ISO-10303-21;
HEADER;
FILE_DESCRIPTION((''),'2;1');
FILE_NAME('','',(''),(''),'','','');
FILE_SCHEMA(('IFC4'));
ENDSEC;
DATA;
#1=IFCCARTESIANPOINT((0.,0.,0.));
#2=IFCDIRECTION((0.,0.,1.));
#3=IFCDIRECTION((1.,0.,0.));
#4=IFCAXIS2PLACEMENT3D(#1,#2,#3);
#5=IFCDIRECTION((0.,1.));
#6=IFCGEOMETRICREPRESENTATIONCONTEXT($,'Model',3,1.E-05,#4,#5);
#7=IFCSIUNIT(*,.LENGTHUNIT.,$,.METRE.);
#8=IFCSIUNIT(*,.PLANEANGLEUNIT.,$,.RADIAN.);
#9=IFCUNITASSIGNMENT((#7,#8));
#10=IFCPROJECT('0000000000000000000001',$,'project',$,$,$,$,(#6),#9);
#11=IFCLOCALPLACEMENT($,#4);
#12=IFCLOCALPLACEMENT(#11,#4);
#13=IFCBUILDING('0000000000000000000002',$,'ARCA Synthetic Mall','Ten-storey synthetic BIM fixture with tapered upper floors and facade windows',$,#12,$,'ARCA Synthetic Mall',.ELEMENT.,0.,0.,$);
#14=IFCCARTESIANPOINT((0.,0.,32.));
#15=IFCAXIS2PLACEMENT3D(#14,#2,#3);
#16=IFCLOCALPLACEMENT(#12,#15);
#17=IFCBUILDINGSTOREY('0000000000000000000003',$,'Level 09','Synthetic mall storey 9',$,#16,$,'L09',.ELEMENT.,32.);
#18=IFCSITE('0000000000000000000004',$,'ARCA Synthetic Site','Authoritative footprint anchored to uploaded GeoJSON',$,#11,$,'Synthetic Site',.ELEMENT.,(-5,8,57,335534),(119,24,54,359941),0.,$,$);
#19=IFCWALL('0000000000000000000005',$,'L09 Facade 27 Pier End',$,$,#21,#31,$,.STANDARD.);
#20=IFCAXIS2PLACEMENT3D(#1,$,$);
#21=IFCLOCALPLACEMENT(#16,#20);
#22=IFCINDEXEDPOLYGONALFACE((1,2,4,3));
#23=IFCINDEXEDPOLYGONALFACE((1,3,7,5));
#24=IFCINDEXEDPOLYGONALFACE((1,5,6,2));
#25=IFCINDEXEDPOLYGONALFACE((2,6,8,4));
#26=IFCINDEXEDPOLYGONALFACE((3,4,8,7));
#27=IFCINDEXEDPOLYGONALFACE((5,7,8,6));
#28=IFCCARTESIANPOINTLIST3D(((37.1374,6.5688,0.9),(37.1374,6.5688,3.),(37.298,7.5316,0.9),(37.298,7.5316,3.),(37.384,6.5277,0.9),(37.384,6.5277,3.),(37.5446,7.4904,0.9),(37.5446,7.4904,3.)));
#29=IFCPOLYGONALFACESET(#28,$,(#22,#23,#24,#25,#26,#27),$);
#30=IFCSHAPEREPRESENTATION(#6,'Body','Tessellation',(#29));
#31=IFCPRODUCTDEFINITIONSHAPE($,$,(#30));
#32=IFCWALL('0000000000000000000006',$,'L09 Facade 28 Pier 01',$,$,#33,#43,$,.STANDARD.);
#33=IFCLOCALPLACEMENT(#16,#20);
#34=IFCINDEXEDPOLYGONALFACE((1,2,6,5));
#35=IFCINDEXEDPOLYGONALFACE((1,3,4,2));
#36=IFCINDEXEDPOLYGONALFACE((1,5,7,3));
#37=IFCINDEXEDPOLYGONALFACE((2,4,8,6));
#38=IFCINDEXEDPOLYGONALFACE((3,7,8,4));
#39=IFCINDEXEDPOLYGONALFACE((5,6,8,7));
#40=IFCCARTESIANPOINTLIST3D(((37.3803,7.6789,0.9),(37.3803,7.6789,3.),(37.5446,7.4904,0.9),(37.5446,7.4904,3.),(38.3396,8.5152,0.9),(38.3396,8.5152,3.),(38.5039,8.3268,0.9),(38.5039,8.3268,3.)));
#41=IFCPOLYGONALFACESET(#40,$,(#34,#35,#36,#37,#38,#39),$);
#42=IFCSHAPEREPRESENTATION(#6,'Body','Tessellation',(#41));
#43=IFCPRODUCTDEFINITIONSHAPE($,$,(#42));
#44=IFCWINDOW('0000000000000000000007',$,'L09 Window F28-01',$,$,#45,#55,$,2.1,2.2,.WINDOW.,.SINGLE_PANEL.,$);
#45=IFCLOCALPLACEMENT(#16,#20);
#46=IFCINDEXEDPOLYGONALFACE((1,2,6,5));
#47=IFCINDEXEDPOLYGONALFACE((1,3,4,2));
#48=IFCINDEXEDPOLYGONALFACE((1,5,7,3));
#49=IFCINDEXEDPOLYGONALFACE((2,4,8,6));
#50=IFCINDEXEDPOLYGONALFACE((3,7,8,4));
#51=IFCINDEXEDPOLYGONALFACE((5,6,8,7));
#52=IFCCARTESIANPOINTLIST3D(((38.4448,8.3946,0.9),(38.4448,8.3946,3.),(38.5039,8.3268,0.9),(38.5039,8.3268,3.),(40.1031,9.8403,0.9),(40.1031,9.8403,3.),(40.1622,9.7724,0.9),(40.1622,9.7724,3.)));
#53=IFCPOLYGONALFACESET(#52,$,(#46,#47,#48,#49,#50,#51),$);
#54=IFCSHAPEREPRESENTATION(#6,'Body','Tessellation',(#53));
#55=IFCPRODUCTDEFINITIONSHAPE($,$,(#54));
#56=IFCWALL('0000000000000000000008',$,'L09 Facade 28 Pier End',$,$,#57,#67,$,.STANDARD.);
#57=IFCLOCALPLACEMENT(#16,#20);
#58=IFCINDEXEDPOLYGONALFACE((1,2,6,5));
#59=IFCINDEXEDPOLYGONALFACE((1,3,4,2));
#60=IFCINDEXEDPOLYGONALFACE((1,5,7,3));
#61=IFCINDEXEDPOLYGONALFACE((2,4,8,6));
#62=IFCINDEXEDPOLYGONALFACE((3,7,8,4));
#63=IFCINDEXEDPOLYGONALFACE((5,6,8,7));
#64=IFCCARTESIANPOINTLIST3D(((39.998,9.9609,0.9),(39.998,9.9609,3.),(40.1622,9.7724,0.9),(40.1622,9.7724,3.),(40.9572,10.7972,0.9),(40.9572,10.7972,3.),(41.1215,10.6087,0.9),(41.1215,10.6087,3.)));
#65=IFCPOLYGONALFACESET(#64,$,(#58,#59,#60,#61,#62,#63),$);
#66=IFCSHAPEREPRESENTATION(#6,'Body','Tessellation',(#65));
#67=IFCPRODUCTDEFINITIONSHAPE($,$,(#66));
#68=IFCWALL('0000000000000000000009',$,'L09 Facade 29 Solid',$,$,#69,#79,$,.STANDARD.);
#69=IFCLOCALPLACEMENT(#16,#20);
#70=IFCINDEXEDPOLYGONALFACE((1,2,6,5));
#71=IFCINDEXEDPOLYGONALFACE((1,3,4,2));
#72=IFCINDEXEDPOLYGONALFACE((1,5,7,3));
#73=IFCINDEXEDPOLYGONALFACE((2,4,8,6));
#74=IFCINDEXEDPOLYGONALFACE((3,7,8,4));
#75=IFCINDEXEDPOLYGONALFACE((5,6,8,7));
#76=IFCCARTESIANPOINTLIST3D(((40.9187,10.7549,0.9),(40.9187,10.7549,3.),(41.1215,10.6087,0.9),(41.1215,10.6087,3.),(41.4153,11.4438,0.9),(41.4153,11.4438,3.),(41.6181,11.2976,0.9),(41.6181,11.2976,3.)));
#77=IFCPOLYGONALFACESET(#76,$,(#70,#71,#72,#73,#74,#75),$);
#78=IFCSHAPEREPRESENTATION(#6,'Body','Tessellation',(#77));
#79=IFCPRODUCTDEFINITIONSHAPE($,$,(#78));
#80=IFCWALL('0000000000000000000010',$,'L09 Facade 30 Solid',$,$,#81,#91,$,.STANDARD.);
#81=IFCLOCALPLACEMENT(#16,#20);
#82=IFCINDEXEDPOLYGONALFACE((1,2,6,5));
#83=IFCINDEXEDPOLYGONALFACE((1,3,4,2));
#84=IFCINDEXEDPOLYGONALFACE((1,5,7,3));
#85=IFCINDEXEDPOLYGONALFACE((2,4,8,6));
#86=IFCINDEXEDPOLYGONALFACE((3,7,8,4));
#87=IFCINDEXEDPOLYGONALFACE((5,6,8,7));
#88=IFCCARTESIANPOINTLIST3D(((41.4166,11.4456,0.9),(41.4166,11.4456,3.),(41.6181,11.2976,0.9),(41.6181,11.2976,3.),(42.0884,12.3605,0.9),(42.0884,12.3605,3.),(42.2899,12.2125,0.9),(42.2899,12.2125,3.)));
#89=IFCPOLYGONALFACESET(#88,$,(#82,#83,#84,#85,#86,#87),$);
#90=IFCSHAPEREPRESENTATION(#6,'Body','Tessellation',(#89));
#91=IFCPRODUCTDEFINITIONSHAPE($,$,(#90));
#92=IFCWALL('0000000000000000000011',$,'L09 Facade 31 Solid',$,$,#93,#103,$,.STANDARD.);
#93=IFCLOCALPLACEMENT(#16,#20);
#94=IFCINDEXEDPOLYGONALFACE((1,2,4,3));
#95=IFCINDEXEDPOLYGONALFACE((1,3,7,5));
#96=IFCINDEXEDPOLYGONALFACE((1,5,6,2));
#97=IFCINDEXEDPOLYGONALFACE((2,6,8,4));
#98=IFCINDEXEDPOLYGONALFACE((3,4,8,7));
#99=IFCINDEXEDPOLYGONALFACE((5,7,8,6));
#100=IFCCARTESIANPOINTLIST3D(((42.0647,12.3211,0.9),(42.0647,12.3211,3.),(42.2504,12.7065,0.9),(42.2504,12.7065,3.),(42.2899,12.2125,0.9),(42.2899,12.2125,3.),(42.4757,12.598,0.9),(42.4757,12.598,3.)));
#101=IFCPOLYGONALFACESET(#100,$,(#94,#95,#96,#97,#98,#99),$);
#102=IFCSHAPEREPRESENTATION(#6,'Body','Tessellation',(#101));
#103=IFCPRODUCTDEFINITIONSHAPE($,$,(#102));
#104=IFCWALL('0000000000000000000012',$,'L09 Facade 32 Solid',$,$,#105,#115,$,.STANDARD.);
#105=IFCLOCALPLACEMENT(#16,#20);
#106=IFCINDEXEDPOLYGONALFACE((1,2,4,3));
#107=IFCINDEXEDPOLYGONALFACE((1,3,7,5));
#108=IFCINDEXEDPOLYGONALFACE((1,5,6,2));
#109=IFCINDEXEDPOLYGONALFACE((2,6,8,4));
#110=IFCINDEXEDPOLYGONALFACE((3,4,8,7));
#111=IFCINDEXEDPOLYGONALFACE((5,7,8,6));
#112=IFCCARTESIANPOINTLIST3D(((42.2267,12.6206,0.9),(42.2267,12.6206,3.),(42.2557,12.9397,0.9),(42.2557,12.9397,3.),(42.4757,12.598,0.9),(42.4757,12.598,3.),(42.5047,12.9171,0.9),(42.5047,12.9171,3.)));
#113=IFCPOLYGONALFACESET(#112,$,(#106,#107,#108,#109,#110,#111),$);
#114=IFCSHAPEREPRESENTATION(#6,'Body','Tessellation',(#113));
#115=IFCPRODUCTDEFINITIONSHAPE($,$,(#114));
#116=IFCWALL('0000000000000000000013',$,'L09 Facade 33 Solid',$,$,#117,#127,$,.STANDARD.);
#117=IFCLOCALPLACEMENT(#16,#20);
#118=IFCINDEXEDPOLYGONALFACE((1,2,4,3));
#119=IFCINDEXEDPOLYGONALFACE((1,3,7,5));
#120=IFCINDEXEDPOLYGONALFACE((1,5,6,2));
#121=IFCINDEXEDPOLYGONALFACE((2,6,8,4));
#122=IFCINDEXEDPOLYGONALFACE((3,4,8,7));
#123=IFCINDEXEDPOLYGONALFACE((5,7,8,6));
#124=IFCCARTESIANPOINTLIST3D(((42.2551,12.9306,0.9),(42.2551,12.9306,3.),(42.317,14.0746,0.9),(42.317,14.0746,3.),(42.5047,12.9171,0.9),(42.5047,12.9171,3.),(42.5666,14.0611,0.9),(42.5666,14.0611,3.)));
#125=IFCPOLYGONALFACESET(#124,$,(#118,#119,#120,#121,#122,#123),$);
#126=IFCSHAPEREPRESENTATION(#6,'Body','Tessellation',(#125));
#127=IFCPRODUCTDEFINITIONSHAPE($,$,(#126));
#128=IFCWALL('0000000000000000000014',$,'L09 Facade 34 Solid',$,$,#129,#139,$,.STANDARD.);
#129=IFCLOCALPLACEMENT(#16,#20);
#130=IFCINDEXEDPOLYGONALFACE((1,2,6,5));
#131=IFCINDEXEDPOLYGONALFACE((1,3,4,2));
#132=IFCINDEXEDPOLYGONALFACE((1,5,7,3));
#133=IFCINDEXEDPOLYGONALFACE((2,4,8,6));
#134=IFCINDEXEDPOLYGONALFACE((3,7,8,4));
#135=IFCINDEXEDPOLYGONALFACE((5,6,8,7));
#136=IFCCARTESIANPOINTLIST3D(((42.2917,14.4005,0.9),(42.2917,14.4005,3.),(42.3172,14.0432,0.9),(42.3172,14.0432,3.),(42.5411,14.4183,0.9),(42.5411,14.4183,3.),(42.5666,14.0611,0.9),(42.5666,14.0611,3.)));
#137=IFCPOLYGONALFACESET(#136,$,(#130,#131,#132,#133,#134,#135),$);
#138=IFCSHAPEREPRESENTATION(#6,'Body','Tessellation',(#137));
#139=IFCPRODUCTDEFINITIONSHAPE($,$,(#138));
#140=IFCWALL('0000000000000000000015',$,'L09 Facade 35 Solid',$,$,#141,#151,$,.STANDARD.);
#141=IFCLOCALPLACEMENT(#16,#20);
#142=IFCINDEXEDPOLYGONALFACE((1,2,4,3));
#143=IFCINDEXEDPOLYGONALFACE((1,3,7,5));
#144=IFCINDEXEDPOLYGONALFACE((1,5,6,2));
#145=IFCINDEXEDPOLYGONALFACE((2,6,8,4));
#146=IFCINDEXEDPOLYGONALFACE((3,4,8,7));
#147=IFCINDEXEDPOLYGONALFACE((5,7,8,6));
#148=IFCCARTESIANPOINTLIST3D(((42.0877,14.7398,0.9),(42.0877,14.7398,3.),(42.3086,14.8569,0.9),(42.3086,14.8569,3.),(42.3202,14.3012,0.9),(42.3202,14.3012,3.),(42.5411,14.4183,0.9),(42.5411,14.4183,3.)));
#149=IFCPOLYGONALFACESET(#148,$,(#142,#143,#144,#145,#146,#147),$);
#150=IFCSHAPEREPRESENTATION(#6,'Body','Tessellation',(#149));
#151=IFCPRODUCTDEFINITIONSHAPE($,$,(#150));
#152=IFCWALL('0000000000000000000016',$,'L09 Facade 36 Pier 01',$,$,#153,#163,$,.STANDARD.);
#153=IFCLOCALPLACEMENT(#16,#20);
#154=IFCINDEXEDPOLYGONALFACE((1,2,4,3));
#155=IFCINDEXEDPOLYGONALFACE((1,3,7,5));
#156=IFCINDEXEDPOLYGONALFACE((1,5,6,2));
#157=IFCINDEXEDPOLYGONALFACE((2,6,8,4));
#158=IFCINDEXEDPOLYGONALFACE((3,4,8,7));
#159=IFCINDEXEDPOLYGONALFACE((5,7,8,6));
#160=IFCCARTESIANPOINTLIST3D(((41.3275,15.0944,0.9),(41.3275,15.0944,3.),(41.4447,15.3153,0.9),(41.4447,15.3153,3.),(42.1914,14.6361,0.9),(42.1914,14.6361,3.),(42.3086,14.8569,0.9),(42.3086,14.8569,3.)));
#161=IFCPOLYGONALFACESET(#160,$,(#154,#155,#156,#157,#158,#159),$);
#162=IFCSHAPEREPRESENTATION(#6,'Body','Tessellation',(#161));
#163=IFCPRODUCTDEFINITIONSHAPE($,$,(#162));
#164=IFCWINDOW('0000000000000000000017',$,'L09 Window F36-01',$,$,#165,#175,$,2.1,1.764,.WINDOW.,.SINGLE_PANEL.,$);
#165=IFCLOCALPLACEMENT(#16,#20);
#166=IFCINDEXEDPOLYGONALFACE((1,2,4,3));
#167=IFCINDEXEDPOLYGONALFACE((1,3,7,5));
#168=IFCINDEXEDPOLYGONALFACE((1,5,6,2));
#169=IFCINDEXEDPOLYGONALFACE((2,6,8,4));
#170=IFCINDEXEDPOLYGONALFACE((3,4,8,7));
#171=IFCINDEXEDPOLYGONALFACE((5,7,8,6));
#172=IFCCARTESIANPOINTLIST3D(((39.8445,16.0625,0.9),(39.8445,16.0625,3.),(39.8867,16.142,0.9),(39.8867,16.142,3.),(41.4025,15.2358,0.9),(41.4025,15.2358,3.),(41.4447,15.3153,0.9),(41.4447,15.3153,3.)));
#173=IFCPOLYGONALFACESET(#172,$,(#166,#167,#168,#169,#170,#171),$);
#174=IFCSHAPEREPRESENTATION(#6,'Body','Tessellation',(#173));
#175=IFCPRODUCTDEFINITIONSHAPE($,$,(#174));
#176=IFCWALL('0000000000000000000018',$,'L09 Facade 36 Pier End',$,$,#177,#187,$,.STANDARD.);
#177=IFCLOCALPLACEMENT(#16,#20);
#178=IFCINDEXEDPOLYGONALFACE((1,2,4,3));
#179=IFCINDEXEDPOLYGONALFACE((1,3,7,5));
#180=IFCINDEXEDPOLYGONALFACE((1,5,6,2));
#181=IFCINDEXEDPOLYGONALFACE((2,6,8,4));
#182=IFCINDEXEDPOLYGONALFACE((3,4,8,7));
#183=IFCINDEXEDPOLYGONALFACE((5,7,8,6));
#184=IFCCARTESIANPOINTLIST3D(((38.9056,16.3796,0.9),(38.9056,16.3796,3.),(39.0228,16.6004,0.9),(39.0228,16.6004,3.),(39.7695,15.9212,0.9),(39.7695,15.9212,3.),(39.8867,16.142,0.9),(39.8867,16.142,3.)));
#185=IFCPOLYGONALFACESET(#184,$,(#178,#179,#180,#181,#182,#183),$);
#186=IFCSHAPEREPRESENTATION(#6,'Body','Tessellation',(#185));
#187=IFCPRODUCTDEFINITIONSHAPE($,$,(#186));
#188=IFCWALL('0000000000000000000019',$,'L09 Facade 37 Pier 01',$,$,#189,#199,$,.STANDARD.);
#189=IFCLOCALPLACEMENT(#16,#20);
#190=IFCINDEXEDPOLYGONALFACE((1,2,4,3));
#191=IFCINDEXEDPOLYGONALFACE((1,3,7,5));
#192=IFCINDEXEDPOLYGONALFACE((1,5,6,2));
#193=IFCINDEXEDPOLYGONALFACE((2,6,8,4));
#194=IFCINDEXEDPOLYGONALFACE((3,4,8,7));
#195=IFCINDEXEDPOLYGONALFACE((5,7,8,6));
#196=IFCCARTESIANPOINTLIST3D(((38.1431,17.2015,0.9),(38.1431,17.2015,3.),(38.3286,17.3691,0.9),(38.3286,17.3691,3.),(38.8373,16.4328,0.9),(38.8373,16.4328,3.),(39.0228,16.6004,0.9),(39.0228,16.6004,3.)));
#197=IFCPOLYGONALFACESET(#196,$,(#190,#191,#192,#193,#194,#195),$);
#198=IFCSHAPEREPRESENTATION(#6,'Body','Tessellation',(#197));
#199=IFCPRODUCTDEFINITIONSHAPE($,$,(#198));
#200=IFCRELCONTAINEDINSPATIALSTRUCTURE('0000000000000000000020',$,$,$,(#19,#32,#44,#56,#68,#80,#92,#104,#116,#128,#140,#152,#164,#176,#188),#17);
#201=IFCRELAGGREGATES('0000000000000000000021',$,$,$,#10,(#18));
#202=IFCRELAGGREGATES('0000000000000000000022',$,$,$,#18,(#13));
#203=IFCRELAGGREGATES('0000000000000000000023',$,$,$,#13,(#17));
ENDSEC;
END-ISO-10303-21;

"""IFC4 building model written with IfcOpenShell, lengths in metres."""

from ifc_helpers import new_model, si_unit, direction, frame, origin_with_axes, place, context, project, spatial, polyline, outline, extrude, element, save


model = new_model("IFC4")

# Units and contexts
model_context = context("Model", 3, precision=1e-05, world=origin_with_axes(), true_north=direction((0.0, 1.0)))
ifc_project = project(units=[si_unit("LENGTHUNIT", "METRE"), si_unit("PLANEANGLEUNIT", "RADIAN")], contexts=[model_context])

# Site, building, storey
site_placement = place(None, origin_with_axes())
site = spatial("IfcSite", under=ifc_project, at=site_placement, Name="ARCA Synthetic Site", Description="Authoritative footprint anchored to uploaded GeoJSON", LongName="Synthetic Site", CompositionType="ELEMENT", RefLatitude=(-5, 8, 57, 335534), RefLongitude=(119, 24, 54, 359941), RefElevation=0.0)
building_placement = place(site_placement, origin_with_axes())
building = spatial("IfcBuilding", under=site, at=building_placement, Name="ARCA Synthetic Mall", Description="Ten-storey synthetic BIM fixture with tapered upper floors and facade windows", LongName="ARCA Synthetic Mall", CompositionType="ELEMENT", ElevationOfRefHeight=0.0, ElevationOfTerrain=0.0)
storey_placement = place(building_placement, frame((0.0, 0.0, 32.0), z_axis=(0.0, 0.0, 1.0), x_axis=(1.0, 0.0, 0.0)))
storey = spatial("IfcBuildingStorey", under=building, at=storey_placement, Name="Level 09", Description="Synthetic mall storey 9", LongName="L09", CompositionType="ELEMENT", Elevation=32.0)

# Walls
wall_1_placement = place(storey_placement, frame((0.0, 0.0, 0.9), z_axis=(0.0, 0.0, 1.0), x_axis=(1.0, 0.0, 0.0)))
element("IfcWall", 1, at=wall_1_placement, inside=storey, Name="L09 Facade 27 Pier End", PredefinedType="STANDARD", context=model_context, shape_type="SweptSolid", body=[
    extrude(outline(polyline([(37.384, 6.5277), (37.5446, 7.4905), (37.298, 7.5316), (37.1374, 6.5688), (37.384, 6.5277)])), origin_with_axes(), (0.0, 0.0, 1.0), 2.1),
])
wall_2_placement = place(storey_placement, frame((0.0, 0.0, 0.9), z_axis=(0.0, 0.0, 1.0), x_axis=(1.0, 0.0, 0.0)))
element("IfcWall", 2, at=wall_2_placement, inside=storey, Name="L09 Facade 28 Pier 01", PredefinedType="STANDARD", context=model_context, shape_type="SweptSolid", body=[
    extrude(outline(polyline([(37.5446, 7.4905), (38.5039, 8.3268), (38.3396, 8.5152), (37.3803, 7.6789), (37.5446, 7.4905)])), origin_with_axes(), (0.0, 0.0, 1.0), 2.1),
])

# Window
window_1_placement = place(storey_placement, frame((0.0, 0.0, 0.9), z_axis=(0.0, 0.0, 1.0), x_axis=(1.0, 0.0, 0.0)))
element("IfcWindow", 3, at=window_1_placement, inside=storey, Name="L09 Window F28-01", OverallHeight=2.1, OverallWidth=2.2, PartitioningType="SINGLE_PANEL", PredefinedType="WINDOW", context=model_context, shape_type="SweptSolid", body=[
    extrude(outline(polyline([(38.5039, 8.3268), (40.1622, 9.7724), (40.1031, 9.8403), (38.4448, 8.3946), (38.5039, 8.3268)])), origin_with_axes(), (0.0, 0.0, 1.0), 2.1),
])

# Walls
wall_3_placement = place(storey_placement, frame((0.0, 0.0, 0.9), z_axis=(0.0, 0.0, 1.0), x_axis=(1.0, 0.0, 0.0)))
element("IfcWall", 4, at=wall_3_placement, inside=storey, Name="L09 Facade 28 Pier End", PredefinedType="STANDARD", context=model_context, shape_type="SweptSolid", body=[
    extrude(outline(polyline([(40.1622, 9.7724), (41.1215, 10.6087), (40.9572, 10.7972), (39.998, 9.9609), (40.1622, 9.7724)])), origin_with_axes(), (0.0, 0.0, 1.0), 2.1),
])
wall_4_placement = place(storey_placement, frame((0.0, 0.0, 0.9), z_axis=(0.0, 0.0, 1.0), x_axis=(1.0, 0.0, 0.0)))
element("IfcWall", 5, at=wall_4_placement, inside=storey, Name="L09 Facade 29 Solid", PredefinedType="STANDARD", context=model_context, shape_type="SweptSolid", body=[
    extrude(outline(polyline([(41.1215, 10.6087), (41.6181, 11.2976), (41.4153, 11.4438), (40.9187, 10.7549), (41.1215, 10.6087)])), origin_with_axes(), (0.0, 0.0, 1.0), 2.1),
])
wall_5_placement = place(storey_placement, frame((0.0, 0.0, 0.9), z_axis=(0.0, 0.0, 1.0), x_axis=(1.0, 0.0, 0.0)))
element("IfcWall", 6, at=wall_5_placement, inside=storey, Name="L09 Facade 30 Solid", PredefinedType="STANDARD", context=model_context, shape_type="SweptSolid", body=[
    extrude(outline(polyline([(41.6181, 11.2976), (42.2899, 12.2125), (42.0884, 12.3605), (41.4166, 11.4456), (41.6181, 11.2976)])), origin_with_axes(), (0.0, 0.0, 1.0), 2.1),
])
wall_6_placement = place(storey_placement, frame((0.0, 0.0, 0.9), z_axis=(0.0, 0.0, 1.0), x_axis=(1.0, 0.0, 0.0)))
element("IfcWall", 7, at=wall_6_placement, inside=storey, Name="L09 Facade 31 Solid", PredefinedType="STANDARD", context=model_context, shape_type="SweptSolid", body=[
    extrude(outline(polyline([(42.2899, 12.2125), (42.4757, 12.598), (42.2504, 12.7065), (42.0647, 12.3211), (42.2899, 12.2125)])), origin_with_axes(), (0.0, 0.0, 1.0), 2.1),
])
wall_7_placement = place(storey_placement, frame((0.0, 0.0, 0.9), z_axis=(0.0, 0.0, 1.0), x_axis=(1.0, 0.0, 0.0)))
element("IfcWall", 8, at=wall_7_placement, inside=storey, Name="L09 Facade 32 Solid", PredefinedType="STANDARD", context=model_context, shape_type="SweptSolid", body=[
    extrude(outline(polyline([(42.4757, 12.598), (42.5047, 12.9171), (42.2557, 12.9397), (42.2267, 12.6206), (42.4757, 12.598)])), origin_with_axes(), (0.0, 0.0, 1.0), 2.1),
])
wall_8_placement = place(storey_placement, frame((0.0, 0.0, 0.9), z_axis=(0.0, 0.0, 1.0), x_axis=(1.0, 0.0, 0.0)))
element("IfcWall", 9, at=wall_8_placement, inside=storey, Name="L09 Facade 33 Solid", PredefinedType="STANDARD", context=model_context, shape_type="SweptSolid", body=[
    extrude(outline(polyline([(42.5047, 12.9171), (42.5666, 14.0611), (42.317, 14.0746), (42.2551, 12.9306), (42.5047, 12.9171)])), origin_with_axes(), (0.0, 0.0, 1.0), 2.1),
])
wall_9_placement = place(storey_placement, frame((0.0, 0.0, 0.9), z_axis=(0.0, 0.0, 1.0), x_axis=(1.0, 0.0, 0.0)))
element("IfcWall", 10, at=wall_9_placement, inside=storey, Name="L09 Facade 34 Solid", PredefinedType="STANDARD", context=model_context, shape_type="SweptSolid", body=[
    extrude(outline(polyline([(42.5666, 14.0611), (42.5411, 14.4183), (42.2917, 14.4005), (42.3172, 14.0432), (42.5666, 14.0611)])), origin_with_axes(), (0.0, 0.0, 1.0), 2.1),
])
wall_10_placement = place(storey_placement, frame((0.0, 0.0, 0.9), z_axis=(0.0, 0.0, 1.0), x_axis=(1.0, 0.0, 0.0)))
element("IfcWall", 11, at=wall_10_placement, inside=storey, Name="L09 Facade 35 Solid", PredefinedType="STANDARD", context=model_context, shape_type="SweptSolid", body=[
    extrude(outline(polyline([(42.5411, 14.4183), (42.3086, 14.8569), (42.0877, 14.7398), (42.3202, 14.3012), (42.5411, 14.4183)])), origin_with_axes(), (0.0, 0.0, 1.0), 2.1),
])
wall_11_placement = place(storey_placement, frame((0.0, 0.0, 0.9), z_axis=(0.0, 0.0, 1.0), x_axis=(1.0, 0.0, 0.0)))
element("IfcWall", 12, at=wall_11_placement, inside=storey, Name="L09 Facade 36 Pier 01", PredefinedType="STANDARD", context=model_context, shape_type="SweptSolid", body=[
    extrude(outline(polyline([(42.3086, 14.8569), (41.4447, 15.3153), (41.3275, 15.0944), (42.1914, 14.6361), (42.3086, 14.8569)])), origin_with_axes(), (0.0, 0.0, 1.0), 2.1),
])

# Window
window_2_placement = place(storey_placement, frame((0.0, 0.0, 0.9), z_axis=(0.0, 0.0, 1.0), x_axis=(1.0, 0.0, 0.0)))
element("IfcWindow", 13, at=window_2_placement, inside=storey, Name="L09 Window F36-01", OverallHeight=2.1, OverallWidth=1.764, PartitioningType="SINGLE_PANEL", PredefinedType="WINDOW", context=model_context, shape_type="SweptSolid", body=[
    extrude(outline(polyline([(41.4447, 15.3153), (39.8867, 16.142), (39.8445, 16.0625), (41.4025, 15.2358), (41.4447, 15.3153)])), origin_with_axes(), (0.0, 0.0, 1.0), 2.1),
])

# Walls
wall_12_placement = place(storey_placement, frame((0.0, 0.0, 0.9), z_axis=(0.0, 0.0, 1.0), x_axis=(1.0, 0.0, 0.0)))
element("IfcWall", 14, at=wall_12_placement, inside=storey, Name="L09 Facade 36 Pier End", PredefinedType="STANDARD", context=model_context, shape_type="SweptSolid", body=[
    extrude(outline(polyline([(39.8867, 16.142), (39.0228, 16.6004), (38.9056, 16.3796), (39.7695, 15.9212), (39.8867, 16.142)])), origin_with_axes(), (0.0, 0.0, 1.0), 2.1),
])
wall_13_placement = place(storey_placement, frame((0.0, 0.0, 0.9), z_axis=(0.0, 0.0, 1.0), x_axis=(1.0, 0.0, 0.0)))
element("IfcWall", 15, at=wall_13_placement, inside=storey, Name="L09 Facade 37 Pier 01", PredefinedType="STANDARD", context=model_context, shape_type="SweptSolid", body=[
    extrude(outline(polyline([(39.0228, 16.6004), (38.3286, 17.3691), (38.1431, 17.2015), (38.8373, 16.4328), (39.0228, 16.6004)])), origin_with_axes(), (0.0, 0.0, 1.0), 2.1),
])

save(model, "model.ifc")
